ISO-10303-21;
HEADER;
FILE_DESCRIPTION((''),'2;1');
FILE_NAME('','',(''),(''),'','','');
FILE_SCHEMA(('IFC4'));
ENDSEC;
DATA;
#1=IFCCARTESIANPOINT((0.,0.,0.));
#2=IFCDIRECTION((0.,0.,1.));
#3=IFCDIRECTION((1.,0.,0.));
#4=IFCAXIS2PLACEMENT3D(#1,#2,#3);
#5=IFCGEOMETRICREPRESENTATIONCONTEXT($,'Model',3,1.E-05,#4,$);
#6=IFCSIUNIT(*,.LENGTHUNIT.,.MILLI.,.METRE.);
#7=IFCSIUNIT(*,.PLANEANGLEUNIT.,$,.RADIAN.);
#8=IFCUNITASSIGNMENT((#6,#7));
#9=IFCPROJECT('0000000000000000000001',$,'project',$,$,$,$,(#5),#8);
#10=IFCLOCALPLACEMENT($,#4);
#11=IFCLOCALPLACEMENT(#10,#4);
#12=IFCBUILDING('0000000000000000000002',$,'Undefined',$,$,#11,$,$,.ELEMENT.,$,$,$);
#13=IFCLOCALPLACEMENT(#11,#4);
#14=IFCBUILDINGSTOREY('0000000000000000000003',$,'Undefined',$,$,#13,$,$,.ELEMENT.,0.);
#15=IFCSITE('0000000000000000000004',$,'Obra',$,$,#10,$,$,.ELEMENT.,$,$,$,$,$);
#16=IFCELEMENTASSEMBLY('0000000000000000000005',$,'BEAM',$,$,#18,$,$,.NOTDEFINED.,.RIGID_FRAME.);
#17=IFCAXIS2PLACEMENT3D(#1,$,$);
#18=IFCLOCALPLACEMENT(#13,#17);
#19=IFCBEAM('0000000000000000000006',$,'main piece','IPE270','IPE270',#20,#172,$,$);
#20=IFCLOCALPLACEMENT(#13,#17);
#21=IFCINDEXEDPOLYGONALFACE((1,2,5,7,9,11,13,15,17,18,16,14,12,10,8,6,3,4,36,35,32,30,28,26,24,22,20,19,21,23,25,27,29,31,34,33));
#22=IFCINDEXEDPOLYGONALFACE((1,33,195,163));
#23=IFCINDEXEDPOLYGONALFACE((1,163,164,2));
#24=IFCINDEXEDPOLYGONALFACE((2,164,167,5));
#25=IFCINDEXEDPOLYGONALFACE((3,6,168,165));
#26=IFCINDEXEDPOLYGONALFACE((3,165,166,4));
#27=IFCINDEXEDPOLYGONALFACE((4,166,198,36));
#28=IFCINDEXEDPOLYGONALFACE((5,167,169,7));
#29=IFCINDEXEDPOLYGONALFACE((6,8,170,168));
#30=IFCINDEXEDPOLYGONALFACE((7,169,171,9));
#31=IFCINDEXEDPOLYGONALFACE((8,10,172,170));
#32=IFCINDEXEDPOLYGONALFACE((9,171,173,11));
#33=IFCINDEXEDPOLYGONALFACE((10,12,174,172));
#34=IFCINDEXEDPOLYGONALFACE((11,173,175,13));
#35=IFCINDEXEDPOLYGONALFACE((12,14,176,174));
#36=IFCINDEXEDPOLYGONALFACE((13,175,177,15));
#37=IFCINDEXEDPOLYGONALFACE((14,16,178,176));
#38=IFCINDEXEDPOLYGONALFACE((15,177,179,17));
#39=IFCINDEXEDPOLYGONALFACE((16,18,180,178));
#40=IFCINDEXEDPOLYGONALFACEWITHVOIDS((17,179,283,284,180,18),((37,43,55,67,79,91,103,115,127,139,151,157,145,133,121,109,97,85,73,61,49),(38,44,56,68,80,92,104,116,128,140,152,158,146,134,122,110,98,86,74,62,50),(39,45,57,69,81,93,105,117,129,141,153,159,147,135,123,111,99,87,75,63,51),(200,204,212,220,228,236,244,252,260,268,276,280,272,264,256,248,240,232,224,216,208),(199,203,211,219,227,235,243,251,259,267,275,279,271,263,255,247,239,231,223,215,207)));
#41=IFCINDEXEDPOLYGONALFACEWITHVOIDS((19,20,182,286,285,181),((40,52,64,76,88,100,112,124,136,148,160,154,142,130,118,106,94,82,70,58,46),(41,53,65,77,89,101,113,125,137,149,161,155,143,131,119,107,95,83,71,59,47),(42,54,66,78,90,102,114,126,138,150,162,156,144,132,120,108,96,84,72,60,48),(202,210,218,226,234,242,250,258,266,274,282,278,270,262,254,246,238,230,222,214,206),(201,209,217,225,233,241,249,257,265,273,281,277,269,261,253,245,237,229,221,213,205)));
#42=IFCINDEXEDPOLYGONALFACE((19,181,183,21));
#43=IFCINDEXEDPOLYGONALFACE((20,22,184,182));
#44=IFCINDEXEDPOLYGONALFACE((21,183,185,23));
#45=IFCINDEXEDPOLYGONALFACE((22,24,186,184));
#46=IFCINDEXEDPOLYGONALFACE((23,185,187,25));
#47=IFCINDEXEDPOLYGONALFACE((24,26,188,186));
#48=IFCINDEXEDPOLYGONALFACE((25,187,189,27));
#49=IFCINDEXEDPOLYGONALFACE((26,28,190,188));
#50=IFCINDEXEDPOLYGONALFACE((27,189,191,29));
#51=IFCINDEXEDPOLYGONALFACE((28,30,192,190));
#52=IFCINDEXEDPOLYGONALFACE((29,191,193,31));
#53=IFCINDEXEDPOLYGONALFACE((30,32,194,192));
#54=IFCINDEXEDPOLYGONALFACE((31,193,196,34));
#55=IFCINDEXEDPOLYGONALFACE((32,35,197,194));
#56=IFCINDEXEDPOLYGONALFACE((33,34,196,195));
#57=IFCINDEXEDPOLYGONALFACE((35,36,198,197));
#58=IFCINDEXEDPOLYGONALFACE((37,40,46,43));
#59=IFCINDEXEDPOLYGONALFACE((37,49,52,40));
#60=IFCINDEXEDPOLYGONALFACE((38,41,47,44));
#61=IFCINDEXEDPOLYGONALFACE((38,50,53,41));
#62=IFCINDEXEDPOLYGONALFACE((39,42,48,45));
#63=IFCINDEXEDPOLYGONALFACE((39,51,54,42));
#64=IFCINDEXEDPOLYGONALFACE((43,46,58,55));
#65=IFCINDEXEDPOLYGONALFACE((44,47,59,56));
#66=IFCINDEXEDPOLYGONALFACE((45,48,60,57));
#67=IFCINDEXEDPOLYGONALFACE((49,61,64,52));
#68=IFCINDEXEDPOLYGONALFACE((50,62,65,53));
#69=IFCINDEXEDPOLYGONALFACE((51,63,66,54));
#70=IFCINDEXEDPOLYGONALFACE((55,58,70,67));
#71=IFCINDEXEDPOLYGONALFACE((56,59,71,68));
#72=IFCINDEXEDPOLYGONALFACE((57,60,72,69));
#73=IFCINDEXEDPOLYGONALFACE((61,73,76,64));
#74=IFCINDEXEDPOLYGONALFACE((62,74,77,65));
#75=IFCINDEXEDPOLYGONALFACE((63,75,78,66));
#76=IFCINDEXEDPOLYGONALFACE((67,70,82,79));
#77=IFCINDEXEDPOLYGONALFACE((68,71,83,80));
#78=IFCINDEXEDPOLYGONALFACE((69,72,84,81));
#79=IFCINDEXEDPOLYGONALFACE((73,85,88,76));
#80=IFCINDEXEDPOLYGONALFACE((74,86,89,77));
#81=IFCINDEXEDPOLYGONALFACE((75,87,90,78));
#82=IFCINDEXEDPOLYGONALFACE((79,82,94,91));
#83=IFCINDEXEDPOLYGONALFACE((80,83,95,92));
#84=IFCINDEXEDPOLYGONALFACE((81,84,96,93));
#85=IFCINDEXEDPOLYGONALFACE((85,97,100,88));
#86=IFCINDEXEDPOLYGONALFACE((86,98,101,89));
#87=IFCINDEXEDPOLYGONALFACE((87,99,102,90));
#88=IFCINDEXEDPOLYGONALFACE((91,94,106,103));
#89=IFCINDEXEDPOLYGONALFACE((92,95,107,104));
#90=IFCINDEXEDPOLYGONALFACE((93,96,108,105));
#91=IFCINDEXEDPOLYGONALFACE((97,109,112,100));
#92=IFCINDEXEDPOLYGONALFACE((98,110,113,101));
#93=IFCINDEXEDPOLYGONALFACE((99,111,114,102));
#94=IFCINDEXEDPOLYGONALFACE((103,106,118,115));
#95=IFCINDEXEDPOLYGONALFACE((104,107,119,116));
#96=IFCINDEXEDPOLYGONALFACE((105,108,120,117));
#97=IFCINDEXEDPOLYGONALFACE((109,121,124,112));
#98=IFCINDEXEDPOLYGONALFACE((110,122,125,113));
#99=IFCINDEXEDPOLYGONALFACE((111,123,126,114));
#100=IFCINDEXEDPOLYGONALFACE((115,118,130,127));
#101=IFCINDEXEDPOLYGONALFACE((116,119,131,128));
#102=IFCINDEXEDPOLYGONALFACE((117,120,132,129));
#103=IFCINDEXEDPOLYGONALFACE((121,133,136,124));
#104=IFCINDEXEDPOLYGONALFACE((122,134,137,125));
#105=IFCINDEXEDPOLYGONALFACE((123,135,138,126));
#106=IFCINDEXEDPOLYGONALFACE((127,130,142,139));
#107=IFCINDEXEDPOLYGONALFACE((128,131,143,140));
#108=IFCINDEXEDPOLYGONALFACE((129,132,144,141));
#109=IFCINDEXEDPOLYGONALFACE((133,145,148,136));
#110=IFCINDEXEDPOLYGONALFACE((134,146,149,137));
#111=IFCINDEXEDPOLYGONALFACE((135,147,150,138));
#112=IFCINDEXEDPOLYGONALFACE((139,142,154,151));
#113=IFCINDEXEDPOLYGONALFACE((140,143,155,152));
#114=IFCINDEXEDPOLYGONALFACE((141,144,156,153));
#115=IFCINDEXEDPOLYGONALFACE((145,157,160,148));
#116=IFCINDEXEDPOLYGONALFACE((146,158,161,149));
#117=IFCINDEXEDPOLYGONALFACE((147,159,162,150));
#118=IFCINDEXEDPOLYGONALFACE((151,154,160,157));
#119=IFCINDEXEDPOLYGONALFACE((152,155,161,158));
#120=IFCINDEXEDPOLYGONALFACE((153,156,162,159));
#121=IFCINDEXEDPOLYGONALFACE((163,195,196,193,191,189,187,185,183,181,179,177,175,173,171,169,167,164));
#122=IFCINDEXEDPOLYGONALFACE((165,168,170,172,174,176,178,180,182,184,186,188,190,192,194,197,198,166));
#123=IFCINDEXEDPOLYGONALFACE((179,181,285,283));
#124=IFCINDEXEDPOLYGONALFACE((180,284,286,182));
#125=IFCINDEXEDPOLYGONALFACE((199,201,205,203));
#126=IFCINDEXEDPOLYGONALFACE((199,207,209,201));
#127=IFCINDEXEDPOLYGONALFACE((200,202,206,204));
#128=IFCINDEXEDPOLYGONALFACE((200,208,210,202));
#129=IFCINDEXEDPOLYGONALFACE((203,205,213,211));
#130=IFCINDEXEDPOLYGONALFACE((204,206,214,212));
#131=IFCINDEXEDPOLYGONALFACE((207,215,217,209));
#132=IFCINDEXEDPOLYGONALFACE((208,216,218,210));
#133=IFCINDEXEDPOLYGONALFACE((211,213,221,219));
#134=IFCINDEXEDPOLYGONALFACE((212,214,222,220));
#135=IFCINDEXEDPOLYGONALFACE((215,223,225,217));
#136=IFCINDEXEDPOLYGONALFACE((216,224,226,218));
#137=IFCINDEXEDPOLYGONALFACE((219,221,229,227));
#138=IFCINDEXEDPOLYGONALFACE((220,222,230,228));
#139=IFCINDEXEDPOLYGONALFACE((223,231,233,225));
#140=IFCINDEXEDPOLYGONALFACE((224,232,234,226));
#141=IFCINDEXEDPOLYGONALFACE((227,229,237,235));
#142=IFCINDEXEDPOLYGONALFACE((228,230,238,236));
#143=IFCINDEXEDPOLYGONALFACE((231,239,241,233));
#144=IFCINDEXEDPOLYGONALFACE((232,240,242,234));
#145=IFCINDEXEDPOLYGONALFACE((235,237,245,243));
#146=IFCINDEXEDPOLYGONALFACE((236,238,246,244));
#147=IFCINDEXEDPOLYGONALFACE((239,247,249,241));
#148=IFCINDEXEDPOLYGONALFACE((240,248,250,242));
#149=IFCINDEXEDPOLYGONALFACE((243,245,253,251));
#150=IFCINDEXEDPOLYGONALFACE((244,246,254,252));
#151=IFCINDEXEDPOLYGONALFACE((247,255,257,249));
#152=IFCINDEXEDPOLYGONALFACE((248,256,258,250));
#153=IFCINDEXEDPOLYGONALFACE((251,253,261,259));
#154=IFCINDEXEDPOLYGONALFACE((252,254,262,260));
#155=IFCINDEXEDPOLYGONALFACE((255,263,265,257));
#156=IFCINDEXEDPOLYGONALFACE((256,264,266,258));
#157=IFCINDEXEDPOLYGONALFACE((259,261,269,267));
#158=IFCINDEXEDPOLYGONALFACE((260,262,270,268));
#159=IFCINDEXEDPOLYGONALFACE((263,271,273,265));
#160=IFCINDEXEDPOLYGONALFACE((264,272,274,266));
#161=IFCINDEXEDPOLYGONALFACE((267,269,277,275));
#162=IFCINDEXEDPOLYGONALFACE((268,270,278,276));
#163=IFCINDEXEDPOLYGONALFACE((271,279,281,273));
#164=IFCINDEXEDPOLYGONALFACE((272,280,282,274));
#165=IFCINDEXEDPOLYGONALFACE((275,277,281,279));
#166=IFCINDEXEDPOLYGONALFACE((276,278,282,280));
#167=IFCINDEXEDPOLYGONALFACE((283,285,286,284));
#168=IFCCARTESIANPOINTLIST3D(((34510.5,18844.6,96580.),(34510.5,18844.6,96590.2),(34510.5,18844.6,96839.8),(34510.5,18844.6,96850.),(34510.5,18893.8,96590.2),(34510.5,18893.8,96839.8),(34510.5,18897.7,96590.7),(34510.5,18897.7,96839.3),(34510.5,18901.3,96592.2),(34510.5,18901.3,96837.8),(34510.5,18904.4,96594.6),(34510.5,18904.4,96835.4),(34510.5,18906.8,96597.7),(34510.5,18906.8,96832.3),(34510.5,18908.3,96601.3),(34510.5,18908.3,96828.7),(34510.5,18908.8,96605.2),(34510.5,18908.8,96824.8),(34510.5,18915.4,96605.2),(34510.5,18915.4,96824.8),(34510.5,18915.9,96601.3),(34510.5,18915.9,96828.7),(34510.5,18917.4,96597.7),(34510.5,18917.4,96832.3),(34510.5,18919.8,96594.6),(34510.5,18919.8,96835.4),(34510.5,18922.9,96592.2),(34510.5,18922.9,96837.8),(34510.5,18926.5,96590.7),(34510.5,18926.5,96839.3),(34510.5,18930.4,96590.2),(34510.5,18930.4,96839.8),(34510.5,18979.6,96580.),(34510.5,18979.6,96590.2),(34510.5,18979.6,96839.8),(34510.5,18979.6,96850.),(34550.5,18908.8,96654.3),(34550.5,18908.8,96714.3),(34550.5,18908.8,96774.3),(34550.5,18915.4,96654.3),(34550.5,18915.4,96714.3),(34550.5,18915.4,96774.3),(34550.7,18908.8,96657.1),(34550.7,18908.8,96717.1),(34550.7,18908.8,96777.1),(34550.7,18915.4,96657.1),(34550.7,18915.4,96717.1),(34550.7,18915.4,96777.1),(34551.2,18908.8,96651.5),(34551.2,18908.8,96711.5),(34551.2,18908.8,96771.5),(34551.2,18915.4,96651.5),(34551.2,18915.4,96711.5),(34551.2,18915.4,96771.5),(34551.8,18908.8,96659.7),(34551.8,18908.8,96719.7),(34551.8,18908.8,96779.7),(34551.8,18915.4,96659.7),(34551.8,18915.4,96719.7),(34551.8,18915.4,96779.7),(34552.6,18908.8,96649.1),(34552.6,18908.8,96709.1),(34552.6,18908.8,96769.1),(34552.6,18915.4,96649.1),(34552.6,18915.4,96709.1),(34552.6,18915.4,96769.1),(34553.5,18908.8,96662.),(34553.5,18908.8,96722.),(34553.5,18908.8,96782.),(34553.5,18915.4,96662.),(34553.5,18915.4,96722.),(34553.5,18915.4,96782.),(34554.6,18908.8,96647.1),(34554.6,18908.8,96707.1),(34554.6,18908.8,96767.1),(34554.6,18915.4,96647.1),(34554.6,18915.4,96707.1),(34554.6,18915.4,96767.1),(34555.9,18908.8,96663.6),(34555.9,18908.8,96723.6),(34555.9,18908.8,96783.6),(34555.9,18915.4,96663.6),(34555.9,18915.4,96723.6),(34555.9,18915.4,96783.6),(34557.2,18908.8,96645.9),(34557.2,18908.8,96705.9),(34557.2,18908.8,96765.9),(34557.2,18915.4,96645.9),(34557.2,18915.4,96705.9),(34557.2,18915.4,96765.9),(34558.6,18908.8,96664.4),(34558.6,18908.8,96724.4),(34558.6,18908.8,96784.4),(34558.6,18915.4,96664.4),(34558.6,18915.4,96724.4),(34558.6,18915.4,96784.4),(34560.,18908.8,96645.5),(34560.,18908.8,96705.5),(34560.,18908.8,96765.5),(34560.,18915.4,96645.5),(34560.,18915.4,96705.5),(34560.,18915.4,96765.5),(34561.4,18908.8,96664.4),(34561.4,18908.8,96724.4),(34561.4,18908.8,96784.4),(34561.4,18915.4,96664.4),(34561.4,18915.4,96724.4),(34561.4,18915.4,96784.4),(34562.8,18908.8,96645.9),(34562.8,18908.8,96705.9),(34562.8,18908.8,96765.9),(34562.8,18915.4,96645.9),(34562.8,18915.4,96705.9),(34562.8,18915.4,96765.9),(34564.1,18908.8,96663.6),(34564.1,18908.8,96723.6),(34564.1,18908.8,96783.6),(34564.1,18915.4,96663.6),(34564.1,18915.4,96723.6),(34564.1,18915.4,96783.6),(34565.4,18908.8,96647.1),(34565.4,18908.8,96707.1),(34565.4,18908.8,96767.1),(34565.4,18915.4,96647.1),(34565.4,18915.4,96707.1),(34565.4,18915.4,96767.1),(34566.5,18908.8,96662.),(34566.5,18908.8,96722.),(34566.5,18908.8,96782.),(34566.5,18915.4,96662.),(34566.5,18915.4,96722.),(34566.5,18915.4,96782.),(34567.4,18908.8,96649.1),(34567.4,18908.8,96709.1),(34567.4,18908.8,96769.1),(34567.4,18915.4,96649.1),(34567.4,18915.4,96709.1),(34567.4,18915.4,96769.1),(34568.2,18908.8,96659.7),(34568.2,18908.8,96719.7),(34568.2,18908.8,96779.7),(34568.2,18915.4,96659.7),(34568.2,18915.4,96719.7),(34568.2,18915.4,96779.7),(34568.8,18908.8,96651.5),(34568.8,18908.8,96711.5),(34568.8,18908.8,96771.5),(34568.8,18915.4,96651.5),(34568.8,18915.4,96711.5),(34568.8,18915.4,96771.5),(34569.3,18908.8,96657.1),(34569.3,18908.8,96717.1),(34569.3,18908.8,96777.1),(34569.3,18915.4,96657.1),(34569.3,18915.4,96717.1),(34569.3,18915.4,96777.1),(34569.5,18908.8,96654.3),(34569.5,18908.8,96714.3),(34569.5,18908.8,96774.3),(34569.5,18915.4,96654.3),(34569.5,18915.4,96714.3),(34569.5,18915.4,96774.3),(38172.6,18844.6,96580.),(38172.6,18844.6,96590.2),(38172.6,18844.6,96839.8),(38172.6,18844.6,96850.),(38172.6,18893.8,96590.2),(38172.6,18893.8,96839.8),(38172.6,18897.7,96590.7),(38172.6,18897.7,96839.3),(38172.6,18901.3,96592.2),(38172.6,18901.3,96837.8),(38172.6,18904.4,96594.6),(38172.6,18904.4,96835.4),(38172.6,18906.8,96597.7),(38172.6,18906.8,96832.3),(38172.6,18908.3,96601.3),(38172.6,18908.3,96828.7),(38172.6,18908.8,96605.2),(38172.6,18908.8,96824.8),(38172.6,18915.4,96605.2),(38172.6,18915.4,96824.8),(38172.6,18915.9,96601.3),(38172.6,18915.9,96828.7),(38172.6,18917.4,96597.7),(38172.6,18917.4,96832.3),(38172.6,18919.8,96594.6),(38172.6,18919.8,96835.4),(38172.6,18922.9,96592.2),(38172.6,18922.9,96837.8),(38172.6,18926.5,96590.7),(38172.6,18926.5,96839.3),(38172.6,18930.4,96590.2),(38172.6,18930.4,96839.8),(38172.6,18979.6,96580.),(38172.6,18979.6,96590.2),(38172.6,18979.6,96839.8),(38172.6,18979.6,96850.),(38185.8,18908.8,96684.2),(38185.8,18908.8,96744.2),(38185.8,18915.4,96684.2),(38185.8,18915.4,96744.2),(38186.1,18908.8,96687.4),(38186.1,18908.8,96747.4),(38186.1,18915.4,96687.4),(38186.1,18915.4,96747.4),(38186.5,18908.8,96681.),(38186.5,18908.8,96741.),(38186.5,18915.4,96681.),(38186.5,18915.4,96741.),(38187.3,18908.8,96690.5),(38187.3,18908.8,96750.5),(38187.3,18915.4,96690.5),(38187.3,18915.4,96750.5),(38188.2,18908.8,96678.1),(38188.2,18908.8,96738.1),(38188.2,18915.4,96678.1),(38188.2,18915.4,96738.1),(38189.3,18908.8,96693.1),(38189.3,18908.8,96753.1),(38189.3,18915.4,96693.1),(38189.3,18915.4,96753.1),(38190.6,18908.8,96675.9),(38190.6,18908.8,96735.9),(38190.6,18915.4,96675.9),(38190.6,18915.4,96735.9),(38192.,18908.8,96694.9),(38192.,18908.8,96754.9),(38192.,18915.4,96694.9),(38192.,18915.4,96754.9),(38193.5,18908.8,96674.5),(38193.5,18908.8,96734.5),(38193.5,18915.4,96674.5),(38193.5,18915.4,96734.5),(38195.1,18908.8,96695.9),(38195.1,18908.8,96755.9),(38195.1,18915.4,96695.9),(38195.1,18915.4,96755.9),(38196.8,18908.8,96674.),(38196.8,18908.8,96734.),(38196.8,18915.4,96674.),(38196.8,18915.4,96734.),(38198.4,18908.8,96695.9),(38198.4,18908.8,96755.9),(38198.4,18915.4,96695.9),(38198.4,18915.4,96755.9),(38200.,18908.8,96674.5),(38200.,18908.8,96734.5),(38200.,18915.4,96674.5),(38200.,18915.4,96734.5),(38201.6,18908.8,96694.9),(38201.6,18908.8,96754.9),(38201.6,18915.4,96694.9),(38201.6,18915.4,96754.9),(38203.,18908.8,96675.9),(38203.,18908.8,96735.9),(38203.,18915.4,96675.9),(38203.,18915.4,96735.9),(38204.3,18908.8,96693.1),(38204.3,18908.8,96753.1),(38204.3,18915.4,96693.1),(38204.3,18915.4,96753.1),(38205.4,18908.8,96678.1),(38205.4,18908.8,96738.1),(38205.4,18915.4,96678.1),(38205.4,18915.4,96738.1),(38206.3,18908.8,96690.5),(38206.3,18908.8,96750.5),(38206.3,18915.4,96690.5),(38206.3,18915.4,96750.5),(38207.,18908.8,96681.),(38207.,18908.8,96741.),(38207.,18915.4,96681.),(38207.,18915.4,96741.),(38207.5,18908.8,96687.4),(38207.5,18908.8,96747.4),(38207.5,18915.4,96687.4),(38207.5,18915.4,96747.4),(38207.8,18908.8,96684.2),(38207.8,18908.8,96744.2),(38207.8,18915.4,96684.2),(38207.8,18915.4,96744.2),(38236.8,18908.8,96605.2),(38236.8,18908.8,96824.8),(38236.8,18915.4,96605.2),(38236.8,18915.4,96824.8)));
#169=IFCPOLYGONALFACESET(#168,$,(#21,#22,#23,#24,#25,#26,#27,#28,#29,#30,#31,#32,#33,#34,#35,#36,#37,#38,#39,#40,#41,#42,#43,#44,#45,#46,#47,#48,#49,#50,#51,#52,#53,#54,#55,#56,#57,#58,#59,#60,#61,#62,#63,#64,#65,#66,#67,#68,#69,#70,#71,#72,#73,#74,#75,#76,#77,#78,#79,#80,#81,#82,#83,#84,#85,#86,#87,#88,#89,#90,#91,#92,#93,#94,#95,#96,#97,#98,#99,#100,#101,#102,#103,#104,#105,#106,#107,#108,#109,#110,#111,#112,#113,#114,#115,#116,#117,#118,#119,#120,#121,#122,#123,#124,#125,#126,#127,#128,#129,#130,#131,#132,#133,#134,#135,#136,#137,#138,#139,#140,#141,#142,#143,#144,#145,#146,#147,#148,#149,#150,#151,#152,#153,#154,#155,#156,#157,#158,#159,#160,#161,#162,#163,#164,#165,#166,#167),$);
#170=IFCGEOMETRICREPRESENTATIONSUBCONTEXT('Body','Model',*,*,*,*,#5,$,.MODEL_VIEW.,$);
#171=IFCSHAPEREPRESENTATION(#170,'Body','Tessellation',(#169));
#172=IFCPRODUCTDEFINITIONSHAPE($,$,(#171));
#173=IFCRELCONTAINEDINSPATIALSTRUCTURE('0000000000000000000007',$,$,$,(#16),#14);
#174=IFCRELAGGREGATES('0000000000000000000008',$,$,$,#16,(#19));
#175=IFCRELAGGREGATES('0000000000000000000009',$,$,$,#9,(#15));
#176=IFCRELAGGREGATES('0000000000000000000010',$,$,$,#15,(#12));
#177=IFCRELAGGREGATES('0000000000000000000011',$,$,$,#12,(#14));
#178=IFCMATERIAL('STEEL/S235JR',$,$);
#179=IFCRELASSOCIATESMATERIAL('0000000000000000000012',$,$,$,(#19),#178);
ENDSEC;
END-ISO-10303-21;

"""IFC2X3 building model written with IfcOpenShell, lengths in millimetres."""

from ifc_helpers import new_model, si_unit, frame, origin_with_axes, origin_2d_with_axis, place, context, subcontext, project, spatial, rectangle, circle, i_section, extrude, clip, halfspace, source, transform, mapped, material, element, aggregate, save


model = new_model("IFC2X3")

# Units and contexts
model_context = context("Model", 3, precision=1e-05, world=origin_with_axes())
body_context = subcontext(model_context, "Body", "Model", "MODEL_VIEW")
ifc_project = project(units=[si_unit("LENGTHUNIT", "METRE", prefix="MILLI"), si_unit("PLANEANGLEUNIT", "RADIAN")], contexts=[model_context])

# Site, building, storey
site_placement = place(None, origin_with_axes())
site = spatial("IfcSite", under=ifc_project, at=site_placement, Name="Obra", CompositionType="ELEMENT")
building_placement = place(site_placement, origin_with_axes())
building = spatial("IfcBuilding", under=site, at=building_placement, Name="Undefined", CompositionType="ELEMENT")
storey_placement = place(building_placement, origin_with_axes())
storey = spatial("IfcBuildingStorey", under=building, at=storey_placement, Name="Undefined", CompositionType="ELEMENT", Elevation=0.0)

# Element assembly, beam, openings
assembly_1_placement = place(storey_placement, origin_with_axes())
assembly_1 = element("IfcElementAssembly", 1, at=assembly_1_placement, inside=storey, Name="BEAM", AssemblyPlace="NOTDEFINED", PredefinedType="RIGID_FRAME")
ifc_material = material(Name="STEEL/S235JR")
beam_1_placement = place(assembly_1_placement, frame((34251.7, 18912.1, 96715.0), z_axis=(0.0, 0.0, 1.0), x_axis=(1.0, 0.0, 0.0)))
beam_1 = element("IfcBeam", 2, at=beam_1_placement, material=ifc_material, Name="main piece", Description="IPE270", ObjectType="IPE270", context=body_context, shape_type="Clipping", body=[
    clip(clip(extrude(i_section(OverallWidth=135.0, OverallDepth=270.0, WebThickness=6.6, FlangeThickness=10.2, FilletRadius=15.0, at=origin_2d_with_axis()), frame((3985.1, 0.0, 0.0), z_axis=(-1.0, 0.0, 0.0), x_axis=(0.0, -1.0, 0.0)), (0.0, 0.0, 1.0), 3985.1), halfspace(frame((258.8, 60.0, -120.0), z_axis=(-1.0, -0.000019, 0.0), x_axis=(0.0, 0.0, 1.0)), False)), halfspace(frame((3985.1, 0.0, -235.0), z_axis=(-1.0, 0.0, 0.0), x_axis=(0.0, 1.0, 0.0)), True)),
])
opening_1_placement = place(assembly_1_placement, frame((34251.7, 18912.1, 96715.0), z_axis=(0.0, 0.0, 1.0), x_axis=(1.0, 0.0, 0.0)))
element("IfcOpeningElement", 3, at=opening_1_placement, cuts=beam_1, ObjectType="Recess", context=body_context, shape_type="SweptSolid", body=[
    extrude(rectangle(XDim=26.2, YDim=76.2, at=origin_2d_with_axis()), frame((3959.0, 68.5, -122.9), z_axis=(0.0, -1.0, 0.0), x_axis=(0.0, 0.0, -1.0)), (0.0, 0.0, 1.0), 137.0),
])
opening_2_placement = place(assembly_1_placement, frame((34251.7, 18912.1, 96715.0), z_axis=(0.0, 0.0, 1.0), x_axis=(1.0, 0.0, 0.0)))
element("IfcOpeningElement", 4, at=opening_2_placement, cuts=beam_1, ObjectType="Recess", context=body_context, shape_type="SweptSolid", body=[
    extrude(rectangle(XDim=26.2, YDim=76.2, at=origin_2d_with_axis()), frame((3959.0, 68.5, 122.9), z_axis=(0.0, -1.0, 0.0), x_axis=(0.0, 0.0, -1.0)), (0.0, 0.0, 1.0), 137.0),
])
shared_shape_1 = source(origin_with_axes(), body_context, "Body", "SweptSolid", [
    extrude(circle(Radius=11.0, at=origin_2d_with_axis()), frame((0.0, -3.4, 0.0), z_axis=(0.0, 1.0, 0.0), x_axis=(1.0, 0.0, 0.0)), (0.0, 0.0, 1.0), 6.8),
])
opening_3_placement = place(assembly_1_placement, frame((38236.8, 18912.1, 96850.0), z_axis=(-1.0, 0.0, 0.0), x_axis=(0.0, 0.0, -1.0)))
element("IfcOpeningElement", 5, at=opening_3_placement, cuts=beam_1, ObjectType="Opening", context=body_context, shape_type="MappedRepresentation", body=[
    mapped(shared_shape_1, transform((105.0, 0.0, 40.0))),
    mapped(shared_shape_1, transform((165.0, 0.0, 40.0))),
])
shared_shape_2 = source(origin_with_axes(), body_context, "Body", "SweptSolid", [
    extrude(circle(Radius=9.5, at=origin_2d_with_axis()), frame((0.0, -3.4, 0.0), z_axis=(0.0, 1.0, 0.0), x_axis=(1.0, 0.0, 0.0)), (0.0, 0.0, 1.0), 6.8),
])
opening_4_placement = place(assembly_1_placement, frame((34510.0, 18912.1, 96835.0), z_axis=(1.0, 0.0, 0.0), x_axis=(0.0, 0.0, -1.0)))
element("IfcOpeningElement", 6, at=opening_4_placement, cuts=beam_1, ObjectType="Opening", context=body_context, shape_type="MappedRepresentation", body=[
    mapped(shared_shape_2, transform((60.0, 0.0, 50.0))),
    mapped(shared_shape_2, transform((120.0, 0.0, 50.0))),
    mapped(shared_shape_2, transform((180.0, 0.0, 50.0))),
])
aggregate(assembly_1, [beam_1])

save(model, "model.ifc")
